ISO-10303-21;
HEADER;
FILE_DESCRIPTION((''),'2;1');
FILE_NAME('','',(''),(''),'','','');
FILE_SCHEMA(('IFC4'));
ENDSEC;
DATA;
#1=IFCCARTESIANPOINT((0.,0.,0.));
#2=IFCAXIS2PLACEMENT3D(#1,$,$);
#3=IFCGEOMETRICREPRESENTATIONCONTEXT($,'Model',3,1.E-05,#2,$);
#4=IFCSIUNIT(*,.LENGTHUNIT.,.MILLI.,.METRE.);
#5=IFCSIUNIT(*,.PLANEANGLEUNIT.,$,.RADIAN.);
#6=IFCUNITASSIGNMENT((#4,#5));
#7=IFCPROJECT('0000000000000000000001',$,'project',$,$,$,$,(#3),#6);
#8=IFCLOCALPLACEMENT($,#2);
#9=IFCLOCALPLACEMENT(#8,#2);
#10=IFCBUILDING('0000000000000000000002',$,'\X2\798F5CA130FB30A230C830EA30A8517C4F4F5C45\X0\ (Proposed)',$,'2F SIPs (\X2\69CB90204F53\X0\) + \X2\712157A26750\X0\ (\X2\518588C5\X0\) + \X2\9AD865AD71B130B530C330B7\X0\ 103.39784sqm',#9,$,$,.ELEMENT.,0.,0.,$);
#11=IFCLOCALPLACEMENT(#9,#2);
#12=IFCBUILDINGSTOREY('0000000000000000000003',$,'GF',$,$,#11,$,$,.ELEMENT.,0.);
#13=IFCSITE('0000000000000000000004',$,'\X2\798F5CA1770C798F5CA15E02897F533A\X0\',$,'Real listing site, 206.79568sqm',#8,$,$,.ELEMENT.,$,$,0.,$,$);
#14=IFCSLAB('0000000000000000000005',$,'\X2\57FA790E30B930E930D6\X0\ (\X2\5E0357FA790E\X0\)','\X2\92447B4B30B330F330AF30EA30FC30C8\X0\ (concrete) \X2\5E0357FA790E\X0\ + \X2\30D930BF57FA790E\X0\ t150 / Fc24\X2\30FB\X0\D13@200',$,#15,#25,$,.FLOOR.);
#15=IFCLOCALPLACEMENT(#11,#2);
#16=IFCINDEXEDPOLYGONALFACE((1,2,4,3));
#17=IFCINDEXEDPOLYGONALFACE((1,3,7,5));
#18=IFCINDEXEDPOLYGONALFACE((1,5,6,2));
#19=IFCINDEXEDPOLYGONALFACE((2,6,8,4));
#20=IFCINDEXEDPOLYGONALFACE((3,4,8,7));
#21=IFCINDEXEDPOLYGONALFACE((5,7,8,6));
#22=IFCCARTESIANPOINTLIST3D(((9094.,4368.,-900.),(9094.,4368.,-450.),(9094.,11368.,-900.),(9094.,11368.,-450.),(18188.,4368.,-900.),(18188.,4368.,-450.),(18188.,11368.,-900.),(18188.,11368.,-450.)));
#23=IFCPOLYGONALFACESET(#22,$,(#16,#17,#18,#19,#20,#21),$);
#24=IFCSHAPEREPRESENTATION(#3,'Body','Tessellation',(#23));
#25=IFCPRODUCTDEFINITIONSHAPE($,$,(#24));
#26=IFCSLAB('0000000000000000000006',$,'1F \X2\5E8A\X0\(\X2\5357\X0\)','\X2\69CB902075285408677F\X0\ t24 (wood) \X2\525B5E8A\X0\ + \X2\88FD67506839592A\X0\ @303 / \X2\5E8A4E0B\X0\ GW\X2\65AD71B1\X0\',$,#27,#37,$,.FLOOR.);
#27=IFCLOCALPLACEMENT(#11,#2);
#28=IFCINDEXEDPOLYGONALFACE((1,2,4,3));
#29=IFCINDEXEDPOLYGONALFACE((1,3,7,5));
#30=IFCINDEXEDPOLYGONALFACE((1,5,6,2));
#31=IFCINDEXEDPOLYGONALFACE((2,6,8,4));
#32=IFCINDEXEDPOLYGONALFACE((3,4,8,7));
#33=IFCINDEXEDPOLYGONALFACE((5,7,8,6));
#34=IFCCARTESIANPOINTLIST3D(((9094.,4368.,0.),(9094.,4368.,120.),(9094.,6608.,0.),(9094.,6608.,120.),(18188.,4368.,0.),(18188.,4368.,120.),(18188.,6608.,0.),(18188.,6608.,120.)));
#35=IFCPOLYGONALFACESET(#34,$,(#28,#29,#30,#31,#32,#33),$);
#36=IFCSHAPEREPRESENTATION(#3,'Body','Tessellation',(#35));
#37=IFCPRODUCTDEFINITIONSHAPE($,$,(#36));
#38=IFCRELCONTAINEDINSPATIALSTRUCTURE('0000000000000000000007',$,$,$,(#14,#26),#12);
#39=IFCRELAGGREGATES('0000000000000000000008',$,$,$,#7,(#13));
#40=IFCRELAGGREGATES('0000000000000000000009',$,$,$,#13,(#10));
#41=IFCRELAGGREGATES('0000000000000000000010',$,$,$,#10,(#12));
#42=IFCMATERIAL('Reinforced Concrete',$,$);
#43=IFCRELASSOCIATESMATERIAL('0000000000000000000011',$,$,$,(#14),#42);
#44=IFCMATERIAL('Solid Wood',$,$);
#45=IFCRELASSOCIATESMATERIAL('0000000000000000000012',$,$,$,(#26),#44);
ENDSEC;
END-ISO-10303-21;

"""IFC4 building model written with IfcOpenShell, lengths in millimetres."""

from ifc_helpers import new_model, si_unit, frame, frame_2d, origin, place, context, project, spatial, rectangle, extrude, material, element, save


model = new_model("IFC4")

# Units and contexts
model_context = context("Model", 3, precision=1e-05, world=origin())
ifc_project = project(units=[si_unit("LENGTHUNIT", "METRE", prefix="MILLI"), si_unit("PLANEANGLEUNIT", "RADIAN")], contexts=[model_context])

# Site, building, storey
site_placement = place(None, origin())
site = spatial("IfcSite", under=ifc_project, at=site_placement, Name="福岡県福岡市西区", ObjectType="Real listing site, 206.79568sqm", CompositionType="ELEMENT", RefElevation=0.0)
building_placement = place(site_placement, origin())
building = spatial("IfcBuilding", under=site, at=building_placement, Name="福岡・アトリエ兼住居 (Proposed)", ObjectType="2F SIPs (構造体) + 無垢材 (内装) + 高断熱サッシ 103.39784sqm", CompositionType="ELEMENT", ElevationOfRefHeight=0.0, ElevationOfTerrain=0.0)
storey_placement = place(building_placement, origin())
storey = spatial("IfcBuildingStorey", under=building, at=storey_placement, Name="GF", CompositionType="ELEMENT", Elevation=0.0)

# Slabs
ifc_material_1 = material(Name="Reinforced Concrete")
slab_1_placement = place(storey_placement, frame((4547.0, 2184.0, -450.0)))
element("IfcSlab", 1, at=slab_1_placement, inside=storey, material=ifc_material_1, Name="基礎スラブ (布基礎)", Description="鉄筋コンクリート (concrete) 布基礎 + ベタ基礎 t150 / Fc24・D13@200", PredefinedType="FLOOR", context=model_context, shape_type="SweptSolid", body=[
    extrude(rectangle(XDim=9094.0, YDim=7000.0, at=frame_2d((4547.0, 3500.0))), frame((4547.0, 2184.0, -450.0)), (0.0, 0.0, 1.0), 450.0),
])
ifc_material_2 = material(Name="Solid Wood")
slab_2_placement = place(storey_placement, frame((4547.0, 2184.0, 0.0)))
element("IfcSlab", 2, at=slab_2_placement, inside=storey, material=ifc_material_2, Name="1F 床(南)", Description="構造用合板 t24 (wood) 剛床 + 製材根太 @303 / 床下 GW断熱", PredefinedType="FLOOR", context=model_context, shape_type="SweptSolid", body=[
    extrude(rectangle(XDim=9094.0, YDim=2240.0, at=frame_2d((4547.0, 1120.0))), frame((4547.0, 2184.0, 0.0)), (0.0, 0.0, 1.0), 120.0),
])

save(model, "model.ifc")
